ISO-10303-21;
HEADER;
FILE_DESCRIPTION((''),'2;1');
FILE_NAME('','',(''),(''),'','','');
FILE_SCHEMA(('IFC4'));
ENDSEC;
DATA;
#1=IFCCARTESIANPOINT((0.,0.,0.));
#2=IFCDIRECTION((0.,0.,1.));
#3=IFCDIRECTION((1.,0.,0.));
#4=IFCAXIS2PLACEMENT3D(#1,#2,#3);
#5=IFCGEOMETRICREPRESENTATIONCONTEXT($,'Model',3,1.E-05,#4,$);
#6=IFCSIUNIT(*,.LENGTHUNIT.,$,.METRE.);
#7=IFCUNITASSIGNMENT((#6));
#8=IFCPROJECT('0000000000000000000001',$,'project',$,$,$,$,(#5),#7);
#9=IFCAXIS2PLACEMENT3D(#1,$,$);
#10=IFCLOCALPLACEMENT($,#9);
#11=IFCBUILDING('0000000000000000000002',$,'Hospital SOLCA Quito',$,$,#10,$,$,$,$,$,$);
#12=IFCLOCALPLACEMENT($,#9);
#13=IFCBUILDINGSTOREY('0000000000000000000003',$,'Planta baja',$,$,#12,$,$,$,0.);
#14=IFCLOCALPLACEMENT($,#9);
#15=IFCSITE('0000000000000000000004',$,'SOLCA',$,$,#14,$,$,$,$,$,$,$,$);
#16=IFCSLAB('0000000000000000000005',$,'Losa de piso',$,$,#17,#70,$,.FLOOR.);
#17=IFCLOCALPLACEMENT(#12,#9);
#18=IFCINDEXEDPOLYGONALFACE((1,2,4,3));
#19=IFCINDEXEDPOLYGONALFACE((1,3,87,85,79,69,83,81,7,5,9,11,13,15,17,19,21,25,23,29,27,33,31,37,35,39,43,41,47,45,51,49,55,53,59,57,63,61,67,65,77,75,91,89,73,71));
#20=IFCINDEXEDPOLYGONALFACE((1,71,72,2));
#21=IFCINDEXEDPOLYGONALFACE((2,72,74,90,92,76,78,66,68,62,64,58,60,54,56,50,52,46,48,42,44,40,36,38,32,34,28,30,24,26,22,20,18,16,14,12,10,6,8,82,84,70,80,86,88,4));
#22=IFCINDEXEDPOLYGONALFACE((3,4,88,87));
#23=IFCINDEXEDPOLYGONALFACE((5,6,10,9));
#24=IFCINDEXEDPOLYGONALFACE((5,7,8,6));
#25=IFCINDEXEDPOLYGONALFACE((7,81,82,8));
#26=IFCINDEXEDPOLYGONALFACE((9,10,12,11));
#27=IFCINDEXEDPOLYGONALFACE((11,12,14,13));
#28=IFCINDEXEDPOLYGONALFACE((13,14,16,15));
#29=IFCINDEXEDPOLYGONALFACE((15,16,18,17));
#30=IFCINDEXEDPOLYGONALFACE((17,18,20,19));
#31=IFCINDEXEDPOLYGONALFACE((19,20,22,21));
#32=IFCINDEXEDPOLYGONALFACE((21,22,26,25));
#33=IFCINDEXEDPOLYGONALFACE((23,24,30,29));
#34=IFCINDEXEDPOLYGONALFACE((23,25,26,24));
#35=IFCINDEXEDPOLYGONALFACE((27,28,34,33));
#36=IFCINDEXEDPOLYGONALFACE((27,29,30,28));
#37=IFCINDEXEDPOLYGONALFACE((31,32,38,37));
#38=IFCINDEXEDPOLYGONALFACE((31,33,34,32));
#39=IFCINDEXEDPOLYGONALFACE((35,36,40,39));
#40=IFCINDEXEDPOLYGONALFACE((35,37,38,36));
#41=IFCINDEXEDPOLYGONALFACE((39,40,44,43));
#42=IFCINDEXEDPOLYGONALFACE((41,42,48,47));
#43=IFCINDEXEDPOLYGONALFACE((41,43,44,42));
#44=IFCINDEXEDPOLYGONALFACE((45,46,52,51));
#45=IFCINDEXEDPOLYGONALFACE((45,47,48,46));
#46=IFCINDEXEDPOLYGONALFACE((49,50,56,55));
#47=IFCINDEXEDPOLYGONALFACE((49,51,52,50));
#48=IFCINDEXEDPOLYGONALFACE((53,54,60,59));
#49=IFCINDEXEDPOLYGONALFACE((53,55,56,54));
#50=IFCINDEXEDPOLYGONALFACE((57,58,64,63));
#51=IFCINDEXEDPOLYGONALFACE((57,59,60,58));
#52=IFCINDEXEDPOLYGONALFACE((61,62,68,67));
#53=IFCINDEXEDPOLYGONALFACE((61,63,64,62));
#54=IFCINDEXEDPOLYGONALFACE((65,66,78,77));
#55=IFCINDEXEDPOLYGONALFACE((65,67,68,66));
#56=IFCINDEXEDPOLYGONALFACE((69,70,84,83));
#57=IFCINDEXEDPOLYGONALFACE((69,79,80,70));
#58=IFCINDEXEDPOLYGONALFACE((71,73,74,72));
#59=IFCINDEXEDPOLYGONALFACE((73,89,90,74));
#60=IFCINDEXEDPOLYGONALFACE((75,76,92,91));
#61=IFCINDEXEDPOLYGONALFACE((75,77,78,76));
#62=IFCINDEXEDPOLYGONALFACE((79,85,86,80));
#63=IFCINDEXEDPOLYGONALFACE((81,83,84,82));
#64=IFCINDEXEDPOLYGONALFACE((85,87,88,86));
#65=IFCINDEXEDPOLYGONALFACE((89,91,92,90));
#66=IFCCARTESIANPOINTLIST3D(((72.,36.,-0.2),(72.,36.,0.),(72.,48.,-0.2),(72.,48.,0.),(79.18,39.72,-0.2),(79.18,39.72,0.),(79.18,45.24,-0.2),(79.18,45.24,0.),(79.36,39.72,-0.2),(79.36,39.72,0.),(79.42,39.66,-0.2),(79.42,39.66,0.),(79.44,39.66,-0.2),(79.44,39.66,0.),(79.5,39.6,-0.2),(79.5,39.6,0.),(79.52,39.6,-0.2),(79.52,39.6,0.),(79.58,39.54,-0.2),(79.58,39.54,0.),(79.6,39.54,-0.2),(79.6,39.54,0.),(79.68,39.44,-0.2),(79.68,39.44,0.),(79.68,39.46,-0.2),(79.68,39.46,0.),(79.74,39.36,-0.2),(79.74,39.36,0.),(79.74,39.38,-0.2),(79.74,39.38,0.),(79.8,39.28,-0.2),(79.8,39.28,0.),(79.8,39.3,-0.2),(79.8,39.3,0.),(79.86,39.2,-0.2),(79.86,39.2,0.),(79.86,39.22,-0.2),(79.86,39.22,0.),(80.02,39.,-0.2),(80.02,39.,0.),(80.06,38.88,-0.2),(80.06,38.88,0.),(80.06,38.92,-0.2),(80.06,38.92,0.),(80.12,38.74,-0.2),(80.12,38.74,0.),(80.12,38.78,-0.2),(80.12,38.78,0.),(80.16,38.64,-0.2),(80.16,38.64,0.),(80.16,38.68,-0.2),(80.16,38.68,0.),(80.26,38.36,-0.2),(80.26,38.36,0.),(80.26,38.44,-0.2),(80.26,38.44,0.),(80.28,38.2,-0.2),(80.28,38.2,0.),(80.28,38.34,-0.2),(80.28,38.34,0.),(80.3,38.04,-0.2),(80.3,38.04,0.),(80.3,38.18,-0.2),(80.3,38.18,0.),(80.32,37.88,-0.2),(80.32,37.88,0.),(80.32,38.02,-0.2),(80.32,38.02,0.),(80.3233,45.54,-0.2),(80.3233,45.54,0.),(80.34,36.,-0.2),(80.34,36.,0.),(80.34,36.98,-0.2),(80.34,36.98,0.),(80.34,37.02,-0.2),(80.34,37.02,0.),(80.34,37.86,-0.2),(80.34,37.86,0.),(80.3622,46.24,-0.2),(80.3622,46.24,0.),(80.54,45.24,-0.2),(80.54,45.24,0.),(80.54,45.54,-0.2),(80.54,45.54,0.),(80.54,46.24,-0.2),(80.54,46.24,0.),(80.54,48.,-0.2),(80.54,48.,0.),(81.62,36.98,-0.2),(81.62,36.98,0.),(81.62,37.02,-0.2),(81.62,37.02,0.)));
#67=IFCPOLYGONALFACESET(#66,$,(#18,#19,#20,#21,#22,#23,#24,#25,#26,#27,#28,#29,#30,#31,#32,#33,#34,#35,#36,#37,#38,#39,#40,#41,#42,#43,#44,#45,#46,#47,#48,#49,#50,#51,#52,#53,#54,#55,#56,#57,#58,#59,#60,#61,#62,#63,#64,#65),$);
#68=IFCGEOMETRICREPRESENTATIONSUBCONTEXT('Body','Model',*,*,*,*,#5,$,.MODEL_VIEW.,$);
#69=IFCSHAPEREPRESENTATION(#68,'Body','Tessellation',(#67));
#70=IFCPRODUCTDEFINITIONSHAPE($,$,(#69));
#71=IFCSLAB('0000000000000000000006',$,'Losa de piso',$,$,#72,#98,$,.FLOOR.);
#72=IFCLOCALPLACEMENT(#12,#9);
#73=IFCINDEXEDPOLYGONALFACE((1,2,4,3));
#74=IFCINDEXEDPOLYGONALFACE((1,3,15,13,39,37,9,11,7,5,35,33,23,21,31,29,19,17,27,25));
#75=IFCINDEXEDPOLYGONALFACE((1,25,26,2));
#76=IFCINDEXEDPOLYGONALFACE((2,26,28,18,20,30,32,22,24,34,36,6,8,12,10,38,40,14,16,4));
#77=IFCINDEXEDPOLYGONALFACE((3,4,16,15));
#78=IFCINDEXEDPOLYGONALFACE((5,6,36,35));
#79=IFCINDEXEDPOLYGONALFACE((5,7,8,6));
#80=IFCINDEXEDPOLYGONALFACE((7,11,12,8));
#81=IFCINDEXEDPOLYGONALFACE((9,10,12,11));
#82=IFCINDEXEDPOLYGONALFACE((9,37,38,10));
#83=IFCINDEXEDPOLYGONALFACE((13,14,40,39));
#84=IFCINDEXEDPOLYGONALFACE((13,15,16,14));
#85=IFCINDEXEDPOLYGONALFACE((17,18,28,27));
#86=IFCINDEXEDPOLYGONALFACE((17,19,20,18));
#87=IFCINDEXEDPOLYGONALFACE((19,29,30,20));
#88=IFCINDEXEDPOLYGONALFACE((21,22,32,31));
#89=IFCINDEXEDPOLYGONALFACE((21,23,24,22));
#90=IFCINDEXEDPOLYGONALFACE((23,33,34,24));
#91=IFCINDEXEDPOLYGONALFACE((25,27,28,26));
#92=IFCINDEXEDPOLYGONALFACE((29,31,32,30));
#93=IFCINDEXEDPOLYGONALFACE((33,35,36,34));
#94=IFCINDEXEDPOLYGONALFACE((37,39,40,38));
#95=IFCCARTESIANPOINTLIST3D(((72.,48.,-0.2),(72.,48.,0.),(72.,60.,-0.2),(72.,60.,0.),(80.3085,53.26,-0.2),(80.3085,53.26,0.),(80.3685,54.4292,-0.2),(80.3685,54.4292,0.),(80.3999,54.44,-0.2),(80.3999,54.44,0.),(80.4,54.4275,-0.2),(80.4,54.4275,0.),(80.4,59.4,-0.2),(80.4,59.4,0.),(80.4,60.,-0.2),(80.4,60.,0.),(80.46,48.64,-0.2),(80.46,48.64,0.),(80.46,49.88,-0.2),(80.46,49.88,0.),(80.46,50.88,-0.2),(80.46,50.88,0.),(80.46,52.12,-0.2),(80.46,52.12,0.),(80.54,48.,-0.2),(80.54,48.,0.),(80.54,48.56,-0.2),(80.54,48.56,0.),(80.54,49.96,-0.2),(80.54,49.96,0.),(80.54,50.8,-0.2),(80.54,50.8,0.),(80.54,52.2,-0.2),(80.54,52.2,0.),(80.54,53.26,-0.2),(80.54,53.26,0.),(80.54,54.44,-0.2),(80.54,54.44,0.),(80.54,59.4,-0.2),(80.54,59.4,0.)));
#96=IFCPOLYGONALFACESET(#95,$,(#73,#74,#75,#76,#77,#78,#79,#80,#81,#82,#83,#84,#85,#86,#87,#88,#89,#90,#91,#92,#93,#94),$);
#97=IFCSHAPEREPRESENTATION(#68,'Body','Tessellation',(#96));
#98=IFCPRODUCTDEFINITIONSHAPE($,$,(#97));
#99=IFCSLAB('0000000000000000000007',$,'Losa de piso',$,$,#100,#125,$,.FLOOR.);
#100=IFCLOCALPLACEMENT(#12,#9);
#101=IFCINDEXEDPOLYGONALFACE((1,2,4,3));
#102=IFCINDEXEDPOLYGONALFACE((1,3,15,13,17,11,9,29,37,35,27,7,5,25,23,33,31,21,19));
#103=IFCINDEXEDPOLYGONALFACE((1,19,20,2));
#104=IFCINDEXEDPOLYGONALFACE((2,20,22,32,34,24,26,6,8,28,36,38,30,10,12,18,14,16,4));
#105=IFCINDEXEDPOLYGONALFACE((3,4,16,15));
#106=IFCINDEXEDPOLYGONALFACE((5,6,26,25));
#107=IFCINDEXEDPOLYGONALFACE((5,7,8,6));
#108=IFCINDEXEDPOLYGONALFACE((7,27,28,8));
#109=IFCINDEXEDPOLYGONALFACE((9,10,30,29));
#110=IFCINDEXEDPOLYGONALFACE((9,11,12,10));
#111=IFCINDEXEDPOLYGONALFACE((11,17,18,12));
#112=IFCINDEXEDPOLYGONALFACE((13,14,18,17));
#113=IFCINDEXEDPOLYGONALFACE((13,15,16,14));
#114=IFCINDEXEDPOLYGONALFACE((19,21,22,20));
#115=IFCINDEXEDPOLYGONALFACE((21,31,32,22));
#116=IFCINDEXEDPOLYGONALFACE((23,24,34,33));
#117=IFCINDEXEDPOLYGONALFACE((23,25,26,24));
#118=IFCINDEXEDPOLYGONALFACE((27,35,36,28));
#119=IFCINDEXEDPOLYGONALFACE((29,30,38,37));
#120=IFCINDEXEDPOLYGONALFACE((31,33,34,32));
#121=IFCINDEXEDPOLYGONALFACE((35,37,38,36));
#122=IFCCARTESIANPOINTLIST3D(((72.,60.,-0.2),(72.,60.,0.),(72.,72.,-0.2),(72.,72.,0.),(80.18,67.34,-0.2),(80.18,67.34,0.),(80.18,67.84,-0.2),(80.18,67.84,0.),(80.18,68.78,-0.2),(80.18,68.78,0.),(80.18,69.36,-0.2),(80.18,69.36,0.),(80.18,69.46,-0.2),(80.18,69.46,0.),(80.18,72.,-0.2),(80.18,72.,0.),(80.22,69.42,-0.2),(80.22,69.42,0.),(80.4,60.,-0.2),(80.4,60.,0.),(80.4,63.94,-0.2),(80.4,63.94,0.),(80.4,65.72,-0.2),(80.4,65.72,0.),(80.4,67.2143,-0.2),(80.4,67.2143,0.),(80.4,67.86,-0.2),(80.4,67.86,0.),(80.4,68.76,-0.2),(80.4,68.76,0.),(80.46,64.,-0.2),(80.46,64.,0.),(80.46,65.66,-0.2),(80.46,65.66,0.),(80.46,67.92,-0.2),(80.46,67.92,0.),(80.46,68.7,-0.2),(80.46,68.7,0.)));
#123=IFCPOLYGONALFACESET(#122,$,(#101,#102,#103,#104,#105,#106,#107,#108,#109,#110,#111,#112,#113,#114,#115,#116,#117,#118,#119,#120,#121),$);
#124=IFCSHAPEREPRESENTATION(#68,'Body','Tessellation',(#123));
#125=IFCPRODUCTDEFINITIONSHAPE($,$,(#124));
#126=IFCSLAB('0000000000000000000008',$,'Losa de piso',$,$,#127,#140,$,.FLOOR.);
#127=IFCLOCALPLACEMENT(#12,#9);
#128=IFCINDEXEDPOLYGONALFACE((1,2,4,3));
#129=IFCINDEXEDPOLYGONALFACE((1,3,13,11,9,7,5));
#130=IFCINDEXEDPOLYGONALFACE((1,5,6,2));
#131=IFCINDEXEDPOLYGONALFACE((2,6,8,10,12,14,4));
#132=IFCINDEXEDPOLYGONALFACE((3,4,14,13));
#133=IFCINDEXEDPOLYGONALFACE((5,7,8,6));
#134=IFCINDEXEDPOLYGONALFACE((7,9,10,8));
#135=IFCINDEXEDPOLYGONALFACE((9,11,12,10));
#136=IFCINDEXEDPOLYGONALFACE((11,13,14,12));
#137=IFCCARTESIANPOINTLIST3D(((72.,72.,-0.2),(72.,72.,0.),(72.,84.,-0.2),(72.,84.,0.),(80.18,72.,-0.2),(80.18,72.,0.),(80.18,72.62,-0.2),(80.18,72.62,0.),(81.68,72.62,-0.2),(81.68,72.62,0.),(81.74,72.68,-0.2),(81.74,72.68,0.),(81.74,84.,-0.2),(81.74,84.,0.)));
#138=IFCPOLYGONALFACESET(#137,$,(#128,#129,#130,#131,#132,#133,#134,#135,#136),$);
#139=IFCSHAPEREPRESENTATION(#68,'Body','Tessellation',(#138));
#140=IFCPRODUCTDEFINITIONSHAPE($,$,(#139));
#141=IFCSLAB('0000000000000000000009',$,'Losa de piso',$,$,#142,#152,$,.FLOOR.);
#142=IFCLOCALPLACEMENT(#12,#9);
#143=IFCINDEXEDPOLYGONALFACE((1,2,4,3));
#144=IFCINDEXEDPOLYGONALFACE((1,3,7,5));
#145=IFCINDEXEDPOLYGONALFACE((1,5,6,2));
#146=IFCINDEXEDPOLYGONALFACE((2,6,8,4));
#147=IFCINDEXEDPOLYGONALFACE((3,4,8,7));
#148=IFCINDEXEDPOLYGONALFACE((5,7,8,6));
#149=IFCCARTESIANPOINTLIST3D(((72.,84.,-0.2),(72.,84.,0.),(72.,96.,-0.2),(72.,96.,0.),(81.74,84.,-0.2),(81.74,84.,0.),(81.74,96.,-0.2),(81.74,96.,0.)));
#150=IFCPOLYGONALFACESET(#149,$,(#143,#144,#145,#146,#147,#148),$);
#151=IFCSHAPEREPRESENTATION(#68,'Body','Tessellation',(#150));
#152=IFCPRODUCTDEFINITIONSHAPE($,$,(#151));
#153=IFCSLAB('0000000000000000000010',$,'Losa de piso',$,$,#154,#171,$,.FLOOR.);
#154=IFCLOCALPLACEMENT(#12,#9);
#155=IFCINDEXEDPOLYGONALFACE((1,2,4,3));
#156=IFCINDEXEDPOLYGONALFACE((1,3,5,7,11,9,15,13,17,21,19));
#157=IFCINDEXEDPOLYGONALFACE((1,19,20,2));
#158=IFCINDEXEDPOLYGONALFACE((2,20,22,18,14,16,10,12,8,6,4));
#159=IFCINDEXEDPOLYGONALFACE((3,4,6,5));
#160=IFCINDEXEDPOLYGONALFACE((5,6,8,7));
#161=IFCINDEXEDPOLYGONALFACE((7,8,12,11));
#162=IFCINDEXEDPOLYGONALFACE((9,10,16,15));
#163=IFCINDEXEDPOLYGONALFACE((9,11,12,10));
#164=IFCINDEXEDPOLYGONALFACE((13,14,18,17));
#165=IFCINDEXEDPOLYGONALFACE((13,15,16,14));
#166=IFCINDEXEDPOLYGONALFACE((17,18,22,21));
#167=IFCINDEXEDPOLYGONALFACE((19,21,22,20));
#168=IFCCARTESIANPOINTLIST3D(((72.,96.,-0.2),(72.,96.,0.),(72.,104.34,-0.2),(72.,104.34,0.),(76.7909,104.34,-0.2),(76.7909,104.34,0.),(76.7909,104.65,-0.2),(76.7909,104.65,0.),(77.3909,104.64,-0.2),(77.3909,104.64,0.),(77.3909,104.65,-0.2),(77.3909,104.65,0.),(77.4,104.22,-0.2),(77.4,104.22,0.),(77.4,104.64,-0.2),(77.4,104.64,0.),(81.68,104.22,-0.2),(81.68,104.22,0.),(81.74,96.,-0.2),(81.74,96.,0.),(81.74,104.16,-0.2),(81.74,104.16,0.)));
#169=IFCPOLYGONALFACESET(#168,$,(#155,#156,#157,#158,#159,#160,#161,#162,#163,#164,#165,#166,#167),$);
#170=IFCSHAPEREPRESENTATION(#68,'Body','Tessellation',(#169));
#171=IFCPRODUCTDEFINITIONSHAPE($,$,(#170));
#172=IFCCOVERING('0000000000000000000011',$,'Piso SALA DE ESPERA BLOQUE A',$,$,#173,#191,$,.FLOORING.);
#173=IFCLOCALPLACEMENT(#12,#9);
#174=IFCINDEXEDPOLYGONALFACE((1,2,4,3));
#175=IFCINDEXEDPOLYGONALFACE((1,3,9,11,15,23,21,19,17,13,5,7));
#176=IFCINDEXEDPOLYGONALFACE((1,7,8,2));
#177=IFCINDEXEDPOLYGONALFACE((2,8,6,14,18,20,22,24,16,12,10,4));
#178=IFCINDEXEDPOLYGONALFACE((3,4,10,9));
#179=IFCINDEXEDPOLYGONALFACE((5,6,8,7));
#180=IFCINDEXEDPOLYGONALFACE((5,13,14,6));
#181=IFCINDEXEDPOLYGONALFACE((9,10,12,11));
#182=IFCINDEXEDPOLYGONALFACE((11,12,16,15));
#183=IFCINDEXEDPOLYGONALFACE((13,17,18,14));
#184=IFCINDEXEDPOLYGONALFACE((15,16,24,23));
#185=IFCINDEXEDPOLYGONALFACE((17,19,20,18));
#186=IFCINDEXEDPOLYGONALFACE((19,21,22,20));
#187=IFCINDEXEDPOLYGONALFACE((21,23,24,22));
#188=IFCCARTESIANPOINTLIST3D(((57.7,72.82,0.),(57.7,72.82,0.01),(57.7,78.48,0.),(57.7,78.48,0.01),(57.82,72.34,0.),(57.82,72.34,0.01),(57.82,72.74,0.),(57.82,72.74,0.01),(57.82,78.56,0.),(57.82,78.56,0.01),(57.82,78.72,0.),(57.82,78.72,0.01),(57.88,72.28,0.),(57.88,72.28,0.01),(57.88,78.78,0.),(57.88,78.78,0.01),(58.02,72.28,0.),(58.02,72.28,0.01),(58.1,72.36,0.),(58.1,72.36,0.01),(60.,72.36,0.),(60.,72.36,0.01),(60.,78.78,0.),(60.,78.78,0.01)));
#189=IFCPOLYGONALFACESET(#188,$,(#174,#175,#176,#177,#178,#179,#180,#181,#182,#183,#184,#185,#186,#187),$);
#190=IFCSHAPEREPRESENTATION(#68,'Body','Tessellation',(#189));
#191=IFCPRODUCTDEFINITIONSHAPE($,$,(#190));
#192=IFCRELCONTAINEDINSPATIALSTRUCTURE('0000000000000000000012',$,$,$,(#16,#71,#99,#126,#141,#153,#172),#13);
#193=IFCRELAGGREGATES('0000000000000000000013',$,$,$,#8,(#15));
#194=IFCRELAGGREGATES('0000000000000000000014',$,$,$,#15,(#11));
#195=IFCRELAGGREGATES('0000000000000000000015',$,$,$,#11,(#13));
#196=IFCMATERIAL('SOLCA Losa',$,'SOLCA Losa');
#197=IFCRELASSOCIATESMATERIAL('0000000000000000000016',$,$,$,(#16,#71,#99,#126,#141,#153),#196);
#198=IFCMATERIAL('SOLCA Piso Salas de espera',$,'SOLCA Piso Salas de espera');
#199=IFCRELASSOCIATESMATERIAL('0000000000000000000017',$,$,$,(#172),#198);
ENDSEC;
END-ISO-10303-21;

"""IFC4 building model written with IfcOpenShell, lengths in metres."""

from ifc_helpers import new_model, si_unit, frame, origin, origin_with_axes, place, context, subcontext, project, spatial, polyline, outline, extrude, material, element, save


model = new_model("IFC4")

# Units and contexts
model_context = context("Model", 3, precision=1e-05, world=origin_with_axes())
body_context = subcontext(model_context, "Body", "Model", "MODEL_VIEW")
ifc_project = project(units=[si_unit("LENGTHUNIT", "METRE")], contexts=[model_context])

# Site, building, storey
site_placement = place(None, origin())
site = spatial("IfcSite", under=ifc_project, at=site_placement, Name="SOLCA")
building_placement = place(None, origin())
building = spatial("IfcBuilding", under=site, at=building_placement, Name="Hospital SOLCA Quito")
storey_placement = place(None, origin())
storey = spatial("IfcBuildingStorey", under=building, at=storey_placement, Name="Planta baja", Elevation=0.0)

# Slabs
ifc_material_1 = material(Name="SOLCA Losa", Category="SOLCA Losa")
slab_1_placement = place(storey_placement, origin_with_axes())
element("IfcSlab", 1, at=slab_1_placement, inside=storey, material=ifc_material_1, Name="Losa de piso", PredefinedType="FLOOR", context=body_context, shape_type="SweptSolid", body=[
    extrude(outline(polyline([(80.54, 46.24), (80.3622, 46.24), (80.3233, 45.54), (80.54, 45.54), (80.54, 45.24), (79.18, 45.24), (79.18, 39.72), (79.36, 39.72), (79.42, 39.66), (79.44, 39.66), (79.5, 39.6), (79.52, 39.6), (79.58, 39.54), (79.6, 39.54), (79.68, 39.46), (79.68, 39.44), (79.74, 39.38), (79.74, 39.36), (79.8, 39.3), (79.8, 39.28), (79.86, 39.22), (79.86, 39.2), (80.02, 39.0), (80.06, 38.92), (80.06, 38.88), (80.12, 38.78), (80.12, 38.74), (80.16, 38.68), (80.16, 38.64), (80.26, 38.44), (80.26, 38.36), (80.28, 38.34), (80.28, 38.2), (80.3, 38.18), (80.3, 38.04), (80.32, 38.02), (80.32, 37.88), (80.34, 37.86), (80.34, 37.02), (81.62, 37.02), (81.62, 36.98), (80.34, 36.98), (80.34, 36.0), (72.0, 36.0), (72.0, 48.0), (80.54, 48.0), (80.54, 46.24)])), frame((0.0, 0.0, -0.2), z_axis=(0.0, 0.0, 1.0), x_axis=(1.0, 0.0, 0.0)), (0.0, 0.0, 1.0), 0.2),
])
slab_2_placement = place(storey_placement, origin_with_axes())
element("IfcSlab", 2, at=slab_2_placement, inside=storey, material=ifc_material_1, Name="Losa de piso", PredefinedType="FLOOR", context=body_context, shape_type="SweptSolid", body=[
    extrude(outline(polyline([(80.4, 59.4), (80.54, 59.4), (80.54, 54.44), (80.3999, 54.44), (80.4, 54.4275), (80.3685, 54.4292), (80.3085, 53.26), (80.54, 53.26), (80.54, 52.2), (80.46, 52.12), (80.46, 50.88), (80.54, 50.8), (80.54, 49.96), (80.46, 49.88), (80.46, 48.64), (80.54, 48.56), (80.54, 48.0), (72.0, 48.0), (72.0, 60.0), (80.4, 60.0), (80.4, 59.4)])), frame((0.0, 0.0, -0.2), z_axis=(0.0, 0.0, 1.0), x_axis=(1.0, 0.0, 0.0)), (0.0, 0.0, 1.0), 0.2),
])
slab_3_placement = place(storey_placement, origin_with_axes())
element("IfcSlab", 3, at=slab_3_placement, inside=storey, material=ifc_material_1, Name="Losa de piso", PredefinedType="FLOOR", context=body_context, shape_type="SweptSolid", body=[
    extrude(outline(polyline([(80.18, 69.46), (80.22, 69.42), (80.18, 69.36), (80.18, 68.78), (80.4, 68.76), (80.46, 68.7), (80.46, 67.92), (80.4, 67.86), (80.18, 67.84), (80.18, 67.34), (80.4, 67.2143), (80.4, 65.72), (80.46, 65.66), (80.46, 64.0), (80.4, 63.94), (80.4, 60.0), (72.0, 60.0), (72.0, 72.0), (80.18, 72.0), (80.18, 69.46)])), frame((0.0, 0.0, -0.2), z_axis=(0.0, 0.0, 1.0), x_axis=(1.0, 0.0, 0.0)), (0.0, 0.0, 1.0), 0.2),
])
slab_4_placement = place(storey_placement, origin_with_axes())
element("IfcSlab", 4, at=slab_4_placement, inside=storey, material=ifc_material_1, Name="Losa de piso", PredefinedType="FLOOR", context=body_context, shape_type="SweptSolid", body=[
    extrude(outline(polyline([(81.74, 72.68), (81.68, 72.62), (80.18, 72.62), (80.18, 72.0), (72.0, 72.0), (72.0, 84.0), (81.74, 84.0), (81.74, 72.68)])), frame((0.0, 0.0, -0.2), z_axis=(0.0, 0.0, 1.0), x_axis=(1.0, 0.0, 0.0)), (0.0, 0.0, 1.0), 0.2),
])
slab_5_placement = place(storey_placement, origin_with_axes())
element("IfcSlab", 5, at=slab_5_placement, inside=storey, material=ifc_material_1, Name="Losa de piso", PredefinedType="FLOOR", context=body_context, shape_type="SweptSolid", body=[
    extrude(outline(polyline([(81.74, 84.0), (72.0, 84.0), (72.0, 96.0), (81.74, 96.0), (81.74, 84.0)])), frame((0.0, 0.0, -0.2), z_axis=(0.0, 0.0, 1.0), x_axis=(1.0, 0.0, 0.0)), (0.0, 0.0, 1.0), 0.2),
])
slab_6_placement = place(storey_placement, origin_with_axes())
element("IfcSlab", 6, at=slab_6_placement, inside=storey, material=ifc_material_1, Name="Losa de piso", PredefinedType="FLOOR", context=body_context, shape_type="SweptSolid", body=[
    extrude(outline(polyline([(76.7909, 104.34), (76.7909, 104.65), (77.3909, 104.65), (77.3909, 104.64), (77.4, 104.64), (77.4, 104.22), (81.68, 104.22), (81.74, 104.16), (81.74, 96.0), (72.0, 96.0), (72.0, 104.34), (76.7909, 104.34)])), frame((0.0, 0.0, -0.2), z_axis=(0.0, 0.0, 1.0), x_axis=(1.0, 0.0, 0.0)), (0.0, 0.0, 1.0), 0.2),
])

# Covering
ifc_material_2 = material(Name="SOLCA Piso Salas de espera", Category="SOLCA Piso Salas de espera")
covering_1_placement = place(storey_placement, origin_with_axes())
element("IfcCovering", 7, at=covering_1_placement, inside=storey, material=ifc_material_2, Name="Piso SALA DE ESPERA BLOQUE A", PredefinedType="FLOORING", context=body_context, shape_type="SweptSolid", body=[
    extrude(outline(polyline([(58.1, 72.36), (58.02, 72.28), (57.88, 72.28), (57.82, 72.34), (57.82, 72.74), (57.7, 72.82), (57.7, 78.48), (57.82, 78.56), (57.82, 78.72), (57.88, 78.78), (60.0, 78.78), (60.0, 72.36), (58.1, 72.36)])), origin_with_axes(), (0.0, 0.0, 1.0), 0.01),
])

save(model, "model.ifc")
